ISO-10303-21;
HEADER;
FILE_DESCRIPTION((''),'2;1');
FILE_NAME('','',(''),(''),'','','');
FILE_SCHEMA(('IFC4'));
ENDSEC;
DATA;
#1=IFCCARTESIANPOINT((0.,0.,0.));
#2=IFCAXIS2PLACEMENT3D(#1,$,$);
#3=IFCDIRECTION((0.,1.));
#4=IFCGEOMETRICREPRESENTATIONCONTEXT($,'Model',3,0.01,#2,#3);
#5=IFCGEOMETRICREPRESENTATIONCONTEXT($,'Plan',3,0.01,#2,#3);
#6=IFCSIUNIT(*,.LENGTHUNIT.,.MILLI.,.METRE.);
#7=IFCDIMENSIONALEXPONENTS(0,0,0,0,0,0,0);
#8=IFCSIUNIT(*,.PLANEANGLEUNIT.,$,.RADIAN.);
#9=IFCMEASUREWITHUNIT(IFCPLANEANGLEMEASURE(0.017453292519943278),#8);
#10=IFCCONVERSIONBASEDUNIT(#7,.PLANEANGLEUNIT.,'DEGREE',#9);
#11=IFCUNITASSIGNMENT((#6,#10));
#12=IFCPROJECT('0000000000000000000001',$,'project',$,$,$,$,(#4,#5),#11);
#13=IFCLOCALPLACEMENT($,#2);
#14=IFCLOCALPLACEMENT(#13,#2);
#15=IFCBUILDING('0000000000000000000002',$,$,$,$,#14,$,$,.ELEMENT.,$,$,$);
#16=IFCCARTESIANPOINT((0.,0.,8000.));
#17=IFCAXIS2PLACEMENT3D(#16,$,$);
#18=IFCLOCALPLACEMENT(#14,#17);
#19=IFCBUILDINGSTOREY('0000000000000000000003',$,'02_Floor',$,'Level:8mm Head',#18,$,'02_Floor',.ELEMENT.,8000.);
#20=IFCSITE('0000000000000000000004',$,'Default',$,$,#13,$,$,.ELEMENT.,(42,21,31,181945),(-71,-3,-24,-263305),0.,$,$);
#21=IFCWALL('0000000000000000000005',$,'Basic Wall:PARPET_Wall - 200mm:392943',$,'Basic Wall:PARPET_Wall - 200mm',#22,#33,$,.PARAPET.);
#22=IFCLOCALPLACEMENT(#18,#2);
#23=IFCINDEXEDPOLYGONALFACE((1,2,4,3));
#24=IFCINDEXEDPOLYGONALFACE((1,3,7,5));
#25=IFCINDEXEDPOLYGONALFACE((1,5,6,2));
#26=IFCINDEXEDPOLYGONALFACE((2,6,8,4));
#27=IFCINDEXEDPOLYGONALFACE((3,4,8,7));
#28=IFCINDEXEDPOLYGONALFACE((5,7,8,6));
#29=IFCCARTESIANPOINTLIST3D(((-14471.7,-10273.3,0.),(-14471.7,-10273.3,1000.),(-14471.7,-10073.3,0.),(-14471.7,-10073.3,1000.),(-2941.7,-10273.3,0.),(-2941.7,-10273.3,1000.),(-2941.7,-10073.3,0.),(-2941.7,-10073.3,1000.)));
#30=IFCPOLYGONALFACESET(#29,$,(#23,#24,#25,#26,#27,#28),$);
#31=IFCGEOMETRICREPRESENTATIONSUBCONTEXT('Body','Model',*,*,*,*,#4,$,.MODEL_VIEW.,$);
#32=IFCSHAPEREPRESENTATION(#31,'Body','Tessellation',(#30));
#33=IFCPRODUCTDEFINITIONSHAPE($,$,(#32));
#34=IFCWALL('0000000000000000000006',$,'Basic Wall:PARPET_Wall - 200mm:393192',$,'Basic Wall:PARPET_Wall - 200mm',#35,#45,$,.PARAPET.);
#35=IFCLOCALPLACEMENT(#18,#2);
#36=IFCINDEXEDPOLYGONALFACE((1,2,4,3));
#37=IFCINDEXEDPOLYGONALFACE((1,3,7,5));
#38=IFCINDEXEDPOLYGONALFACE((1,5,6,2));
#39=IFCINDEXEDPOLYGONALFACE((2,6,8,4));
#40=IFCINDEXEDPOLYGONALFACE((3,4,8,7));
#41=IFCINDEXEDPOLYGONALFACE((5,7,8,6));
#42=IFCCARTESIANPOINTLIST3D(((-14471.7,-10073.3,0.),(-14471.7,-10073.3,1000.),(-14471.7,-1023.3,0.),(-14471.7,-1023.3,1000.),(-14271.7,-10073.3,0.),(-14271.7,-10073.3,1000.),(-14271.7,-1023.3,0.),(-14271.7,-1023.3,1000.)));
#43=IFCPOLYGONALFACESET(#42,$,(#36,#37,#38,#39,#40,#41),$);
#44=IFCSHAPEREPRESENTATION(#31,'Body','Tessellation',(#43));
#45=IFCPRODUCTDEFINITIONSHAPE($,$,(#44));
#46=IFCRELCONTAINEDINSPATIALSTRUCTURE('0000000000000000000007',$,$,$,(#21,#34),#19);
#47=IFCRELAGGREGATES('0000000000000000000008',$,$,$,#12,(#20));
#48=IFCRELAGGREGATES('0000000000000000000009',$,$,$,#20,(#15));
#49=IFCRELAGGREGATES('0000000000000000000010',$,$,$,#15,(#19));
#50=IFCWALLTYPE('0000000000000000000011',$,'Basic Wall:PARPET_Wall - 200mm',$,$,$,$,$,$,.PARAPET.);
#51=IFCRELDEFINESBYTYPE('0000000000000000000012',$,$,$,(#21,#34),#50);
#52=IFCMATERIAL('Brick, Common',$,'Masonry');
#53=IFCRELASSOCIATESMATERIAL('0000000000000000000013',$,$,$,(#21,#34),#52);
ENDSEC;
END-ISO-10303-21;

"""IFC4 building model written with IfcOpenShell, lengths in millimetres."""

from ifc_helpers import new_model, entity, si_unit, converted_unit, direction, frame, origin, place, context, subcontext, project, spatial, indexed_curve, outline, extrude, material, type_object, element, save


model = new_model("IFC4")

# Units and contexts
model_context = context("Model", 3, precision=0.01, world=origin(), true_north=direction((0.0, 1.0)))
plan_context = context("Plan", 3, precision=0.01, world=origin(), true_north=direction((0.0, 1.0)))
body_context = subcontext(model_context, "Body", "Model", "MODEL_VIEW")
ifc_project = project(units=[si_unit("LENGTHUNIT", "METRE", prefix="MILLI"), converted_unit("PLANEANGLEUNIT", "DEGREE", entity("IfcPlaneAngleMeasure", 0.017453292519943278), si_unit("PLANEANGLEUNIT", "RADIAN"), dimensions=[0, 0, 0, 0, 0, 0, 0])], contexts=[model_context, plan_context])

# Site, building, storey
site_placement = place(None, origin())
site = spatial("IfcSite", under=ifc_project, at=site_placement, Name="Default", CompositionType="ELEMENT", RefLatitude=(42, 21, 31, 181945), RefLongitude=(-71, -3, -24, -263305), RefElevation=0.0)
building_placement = place(site_placement, origin())
building = spatial("IfcBuilding", under=site, at=building_placement, CompositionType="ELEMENT")
storey_placement = place(building_placement, frame((0.0, 0.0, 8000.0)))
storey = spatial("IfcBuildingStorey", under=building, at=storey_placement, Name="02_Floor", ObjectType="Level:8mm Head", LongName="02_Floor", CompositionType="ELEMENT", Elevation=8000.0)

# Walls
ifc_material_1 = material(Name="Brick, Common", Category="Masonry")
wall_type = type_object("IfcWallType", Name="Basic Wall:PARPET_Wall - 200mm", PredefinedType="PARAPET")
wall_1_placement = place(storey_placement, frame((-2941.7, -10173.3, 0.0), z_axis=(0.0, 0.0, 1.0), x_axis=(-1.0, 0.0, 0.0)))
element("IfcWall", 1, at=wall_1_placement, inside=storey, type_object=wall_type, material=ifc_material_1, Name="Basic Wall:PARPET_Wall - 200mm:392943", ObjectType="Basic Wall:PARPET_Wall - 200mm", PredefinedType="PARAPET", context=body_context, shape_type="SweptSolid", body=[
    extrude(outline(indexed_curve([(11530.0, 100.0), (0.0, 100.0), (0.0, -100.0), (11530.0, -100.0), (11530.0, 100.0)], self_intersect=False)), origin(), (0.0, 0.0, 1.0), 1000.0),
])
wall_2_placement = place(storey_placement, frame((-14371.7, -10073.3, 0.0), z_axis=(0.0, 0.0, 1.0), x_axis=(0.0, 1.0, 0.0)))
element("IfcWall", 2, at=wall_2_placement, inside=storey, type_object=wall_type, material=ifc_material_1, Name="Basic Wall:PARPET_Wall - 200mm:393192", ObjectType="Basic Wall:PARPET_Wall - 200mm", PredefinedType="PARAPET", context=body_context, shape_type="SweptSolid", body=[
    extrude(outline(indexed_curve([(9050.0, 100.0), (0.0, 100.0), (0.0, -100.0), (9050.0, -100.0), (9050.0, 100.0)], self_intersect=False)), origin(), (0.0, 0.0, 1.0), 1000.0),
])

save(model, "model.ifc")
